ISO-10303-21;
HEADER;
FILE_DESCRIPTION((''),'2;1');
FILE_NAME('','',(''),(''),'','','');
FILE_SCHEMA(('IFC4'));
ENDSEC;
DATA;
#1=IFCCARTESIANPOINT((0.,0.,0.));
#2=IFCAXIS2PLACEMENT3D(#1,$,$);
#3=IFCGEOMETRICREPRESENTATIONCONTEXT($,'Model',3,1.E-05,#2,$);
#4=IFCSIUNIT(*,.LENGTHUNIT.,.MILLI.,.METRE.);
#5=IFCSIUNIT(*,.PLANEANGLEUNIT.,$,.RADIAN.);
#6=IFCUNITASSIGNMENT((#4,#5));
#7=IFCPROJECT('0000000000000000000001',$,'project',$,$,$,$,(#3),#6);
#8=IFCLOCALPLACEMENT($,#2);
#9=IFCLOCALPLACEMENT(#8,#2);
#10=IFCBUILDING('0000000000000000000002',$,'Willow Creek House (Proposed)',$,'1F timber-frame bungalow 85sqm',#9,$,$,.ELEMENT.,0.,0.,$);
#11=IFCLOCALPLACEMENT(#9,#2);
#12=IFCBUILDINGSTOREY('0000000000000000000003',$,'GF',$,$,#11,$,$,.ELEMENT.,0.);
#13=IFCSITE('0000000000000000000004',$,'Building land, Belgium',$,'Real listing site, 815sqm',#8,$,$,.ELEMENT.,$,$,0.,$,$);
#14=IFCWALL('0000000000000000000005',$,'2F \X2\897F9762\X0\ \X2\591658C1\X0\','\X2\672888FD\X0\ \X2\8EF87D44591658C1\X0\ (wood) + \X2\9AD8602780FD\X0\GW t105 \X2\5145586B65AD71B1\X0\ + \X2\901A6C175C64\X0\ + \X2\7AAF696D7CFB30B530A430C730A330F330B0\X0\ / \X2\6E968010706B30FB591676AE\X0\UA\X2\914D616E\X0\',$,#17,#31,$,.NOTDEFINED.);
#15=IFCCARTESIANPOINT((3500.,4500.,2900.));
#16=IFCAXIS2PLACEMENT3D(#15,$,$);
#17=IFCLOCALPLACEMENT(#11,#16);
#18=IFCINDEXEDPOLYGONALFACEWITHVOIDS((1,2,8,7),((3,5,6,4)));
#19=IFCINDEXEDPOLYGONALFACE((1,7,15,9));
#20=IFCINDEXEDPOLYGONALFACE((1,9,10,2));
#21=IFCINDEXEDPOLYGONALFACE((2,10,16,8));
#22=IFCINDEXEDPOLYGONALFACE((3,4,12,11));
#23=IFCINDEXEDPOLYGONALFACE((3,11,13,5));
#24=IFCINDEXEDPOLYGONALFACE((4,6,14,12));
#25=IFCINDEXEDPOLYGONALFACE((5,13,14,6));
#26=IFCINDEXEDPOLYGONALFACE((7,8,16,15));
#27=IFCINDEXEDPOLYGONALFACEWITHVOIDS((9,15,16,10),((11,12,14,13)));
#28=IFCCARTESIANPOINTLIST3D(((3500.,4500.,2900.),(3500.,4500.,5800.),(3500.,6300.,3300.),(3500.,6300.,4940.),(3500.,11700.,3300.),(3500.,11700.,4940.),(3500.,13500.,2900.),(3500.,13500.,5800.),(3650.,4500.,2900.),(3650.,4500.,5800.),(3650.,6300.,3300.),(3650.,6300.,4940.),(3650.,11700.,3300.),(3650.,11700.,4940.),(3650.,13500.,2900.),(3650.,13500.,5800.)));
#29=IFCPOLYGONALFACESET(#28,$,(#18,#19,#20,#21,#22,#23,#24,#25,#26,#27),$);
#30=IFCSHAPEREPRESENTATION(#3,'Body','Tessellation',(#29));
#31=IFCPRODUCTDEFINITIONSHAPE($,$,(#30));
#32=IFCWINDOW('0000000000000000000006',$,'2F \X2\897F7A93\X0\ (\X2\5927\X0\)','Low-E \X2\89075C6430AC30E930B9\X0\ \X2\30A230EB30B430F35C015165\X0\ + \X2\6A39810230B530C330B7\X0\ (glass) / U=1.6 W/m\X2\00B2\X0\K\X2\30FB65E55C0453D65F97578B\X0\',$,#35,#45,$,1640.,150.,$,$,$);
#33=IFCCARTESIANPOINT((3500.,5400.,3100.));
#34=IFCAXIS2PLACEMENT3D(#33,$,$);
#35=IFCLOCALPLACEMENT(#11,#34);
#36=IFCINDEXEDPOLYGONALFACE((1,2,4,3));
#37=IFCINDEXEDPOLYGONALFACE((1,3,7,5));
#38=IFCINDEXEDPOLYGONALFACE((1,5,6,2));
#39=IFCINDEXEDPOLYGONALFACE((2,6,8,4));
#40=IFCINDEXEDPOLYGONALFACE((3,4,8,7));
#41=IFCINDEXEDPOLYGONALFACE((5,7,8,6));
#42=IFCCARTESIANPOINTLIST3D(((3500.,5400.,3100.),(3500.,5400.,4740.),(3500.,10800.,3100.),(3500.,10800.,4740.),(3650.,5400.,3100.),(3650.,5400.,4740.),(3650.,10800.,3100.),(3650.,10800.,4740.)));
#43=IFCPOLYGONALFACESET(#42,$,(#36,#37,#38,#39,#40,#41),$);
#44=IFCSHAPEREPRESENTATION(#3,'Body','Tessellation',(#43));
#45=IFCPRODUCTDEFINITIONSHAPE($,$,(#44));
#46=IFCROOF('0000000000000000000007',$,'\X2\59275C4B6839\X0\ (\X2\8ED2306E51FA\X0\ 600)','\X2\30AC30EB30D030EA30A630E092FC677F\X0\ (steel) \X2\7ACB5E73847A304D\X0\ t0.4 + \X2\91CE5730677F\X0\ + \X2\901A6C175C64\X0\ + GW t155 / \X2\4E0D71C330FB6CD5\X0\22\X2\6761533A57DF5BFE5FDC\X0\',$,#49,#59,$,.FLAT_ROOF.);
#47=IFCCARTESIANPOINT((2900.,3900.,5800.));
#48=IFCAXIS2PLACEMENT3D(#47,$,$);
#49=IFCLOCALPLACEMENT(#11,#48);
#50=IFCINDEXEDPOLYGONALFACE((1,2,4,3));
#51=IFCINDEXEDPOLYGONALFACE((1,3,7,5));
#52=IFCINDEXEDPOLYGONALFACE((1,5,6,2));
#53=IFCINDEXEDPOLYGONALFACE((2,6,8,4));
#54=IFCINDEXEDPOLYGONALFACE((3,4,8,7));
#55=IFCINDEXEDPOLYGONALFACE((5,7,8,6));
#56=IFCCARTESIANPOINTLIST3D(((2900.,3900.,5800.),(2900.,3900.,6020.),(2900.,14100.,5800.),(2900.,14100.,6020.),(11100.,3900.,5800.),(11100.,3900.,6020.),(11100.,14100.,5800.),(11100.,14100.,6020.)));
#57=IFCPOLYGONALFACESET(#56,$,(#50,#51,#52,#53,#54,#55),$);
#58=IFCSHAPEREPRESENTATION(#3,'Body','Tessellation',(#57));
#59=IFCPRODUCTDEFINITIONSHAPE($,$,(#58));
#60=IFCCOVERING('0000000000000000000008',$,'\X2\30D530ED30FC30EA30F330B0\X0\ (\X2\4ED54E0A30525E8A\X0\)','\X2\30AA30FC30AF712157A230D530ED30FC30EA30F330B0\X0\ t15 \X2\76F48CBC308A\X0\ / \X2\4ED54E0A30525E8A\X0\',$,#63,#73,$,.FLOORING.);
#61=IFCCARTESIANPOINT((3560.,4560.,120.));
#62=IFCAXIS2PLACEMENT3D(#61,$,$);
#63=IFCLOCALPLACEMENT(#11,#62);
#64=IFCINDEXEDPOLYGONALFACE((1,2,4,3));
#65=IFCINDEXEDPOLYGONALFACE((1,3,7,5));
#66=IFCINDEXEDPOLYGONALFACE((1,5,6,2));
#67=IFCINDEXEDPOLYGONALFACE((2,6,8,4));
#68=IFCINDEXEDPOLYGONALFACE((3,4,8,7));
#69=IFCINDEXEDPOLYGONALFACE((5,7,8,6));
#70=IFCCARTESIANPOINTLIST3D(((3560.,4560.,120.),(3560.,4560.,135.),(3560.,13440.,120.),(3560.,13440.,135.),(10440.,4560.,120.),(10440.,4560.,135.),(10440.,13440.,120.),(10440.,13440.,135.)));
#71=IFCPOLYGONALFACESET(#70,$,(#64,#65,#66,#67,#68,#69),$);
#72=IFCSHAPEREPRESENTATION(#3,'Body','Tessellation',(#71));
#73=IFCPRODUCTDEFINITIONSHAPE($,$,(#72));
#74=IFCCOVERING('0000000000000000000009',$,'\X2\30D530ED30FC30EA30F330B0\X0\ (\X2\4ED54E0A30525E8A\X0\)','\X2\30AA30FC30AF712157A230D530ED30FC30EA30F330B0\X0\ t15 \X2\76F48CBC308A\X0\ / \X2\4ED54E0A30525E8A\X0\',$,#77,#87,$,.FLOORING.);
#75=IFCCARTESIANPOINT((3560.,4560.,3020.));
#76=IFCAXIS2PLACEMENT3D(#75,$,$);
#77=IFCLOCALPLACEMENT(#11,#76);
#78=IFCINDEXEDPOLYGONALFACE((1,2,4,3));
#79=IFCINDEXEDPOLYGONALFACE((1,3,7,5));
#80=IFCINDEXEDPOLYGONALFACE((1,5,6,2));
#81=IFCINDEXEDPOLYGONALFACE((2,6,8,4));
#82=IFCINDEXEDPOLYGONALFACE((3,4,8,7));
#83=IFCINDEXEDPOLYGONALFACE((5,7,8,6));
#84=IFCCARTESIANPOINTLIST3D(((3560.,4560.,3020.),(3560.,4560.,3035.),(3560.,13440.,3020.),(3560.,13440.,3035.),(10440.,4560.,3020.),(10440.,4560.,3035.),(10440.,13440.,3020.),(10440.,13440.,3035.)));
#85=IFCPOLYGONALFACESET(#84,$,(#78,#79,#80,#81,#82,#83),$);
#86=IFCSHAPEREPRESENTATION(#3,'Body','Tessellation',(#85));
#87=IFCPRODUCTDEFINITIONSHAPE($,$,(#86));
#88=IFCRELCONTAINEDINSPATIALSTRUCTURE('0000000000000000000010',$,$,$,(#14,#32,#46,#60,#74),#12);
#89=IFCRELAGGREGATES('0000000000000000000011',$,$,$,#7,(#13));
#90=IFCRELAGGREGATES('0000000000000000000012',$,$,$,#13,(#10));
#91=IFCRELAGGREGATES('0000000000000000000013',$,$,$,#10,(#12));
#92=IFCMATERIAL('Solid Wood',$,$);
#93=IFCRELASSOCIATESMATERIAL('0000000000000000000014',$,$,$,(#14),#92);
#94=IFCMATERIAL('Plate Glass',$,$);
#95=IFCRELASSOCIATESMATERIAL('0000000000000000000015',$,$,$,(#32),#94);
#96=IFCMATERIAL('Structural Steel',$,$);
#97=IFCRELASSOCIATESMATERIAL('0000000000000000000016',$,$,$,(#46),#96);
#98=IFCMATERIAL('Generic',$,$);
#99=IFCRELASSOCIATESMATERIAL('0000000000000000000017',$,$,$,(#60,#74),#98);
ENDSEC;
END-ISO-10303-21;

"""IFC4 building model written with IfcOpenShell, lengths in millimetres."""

from ifc_helpers import new_model, si_unit, frame, frame_2d, origin, place, context, project, spatial, rectangle, extrude, material, element, fill, save


model = new_model("IFC4")

# Units and contexts
model_context = context("Model", 3, precision=1e-05, world=origin())
ifc_project = project(units=[si_unit("LENGTHUNIT", "METRE", prefix="MILLI"), si_unit("PLANEANGLEUNIT", "RADIAN")], contexts=[model_context])

# Site, building, storey
site_placement = place(None, origin())
site = spatial("IfcSite", under=ifc_project, at=site_placement, Name="Building land, Belgium", ObjectType="Real listing site, 815sqm", CompositionType="ELEMENT", RefElevation=0.0)
building_placement = place(site_placement, origin())
building = spatial("IfcBuilding", under=site, at=building_placement, Name="Willow Creek House (Proposed)", ObjectType="1F timber-frame bungalow 85sqm", CompositionType="ELEMENT", ElevationOfRefHeight=0.0, ElevationOfTerrain=0.0)
storey_placement = place(building_placement, origin())
storey = spatial("IfcBuildingStorey", under=building, at=storey_placement, Name="GF", CompositionType="ELEMENT", Elevation=0.0)

# Shared definitions
ifc_material_1 = material(Name="Solid Wood")
ifc_material_2 = material(Name="Generic")

# Shared definitions
ifc_material_3 = material(Name="Plate Glass")

# Wall, opening, window
wall_1_placement = place(storey_placement, frame((3500.0, 4500.0, 2900.0)))
wall_1 = element("IfcWall", 1, at=wall_1_placement, inside=storey, material=ifc_material_1, Name="2F 西面 外壁", Description="木製 軸組外壁 (wood) + 高性能GW t105 充填断熱 + 通気層 + 窯業系サイディング / 準耐火・外皮UA配慮", PredefinedType="NOTDEFINED", context=model_context, shape_type="SweptSolid", body=[
    extrude(rectangle(XDim=150.0, YDim=9000.0, at=frame_2d((75.0, 4500.0))), frame((3500.0, 4500.0, 2900.0)), (0.0, 0.0, 1.0), 2900.0),
])
opening_1_placement = place(storey_placement, frame((3500.0, 5400.0, 3100.0)))
opening_1 = element("IfcOpeningElement", 2, at=opening_1_placement, cuts=wall_1, PredefinedType="NOTDEFINED", context=model_context, shape_type="SweptSolid", body=[
    extrude(rectangle(XDim=150.0, YDim=5400.0, at=frame_2d((75.0, 2700.0))), frame((3500.0, 5400.0, 3100.0)), (0.0, 0.0, 1.0), 1640.0),
])
window_1_placement = place(storey_placement, frame((3500.0, 5400.0, 3100.0)))
window_1 = element("IfcWindow", 3, at=window_1_placement, inside=storey, material=ifc_material_3, Name="2F 西窓 (大)", Description="Low-E 複層ガラス アルゴン封入 + 樹脂サッシ (glass) / U=1.6 W/m²K・日射取得型", OverallHeight=1640.0, OverallWidth=150.0, context=model_context, shape_type="SweptSolid", body=[
    extrude(rectangle(XDim=150.0, YDim=5400.0, at=frame_2d((75.0, 2700.0))), frame((3500.0, 5400.0, 3100.0)), (0.0, 0.0, 1.0), 1640.0),
])
fill(opening_1, window_1)

# Roof
ifc_material_4 = material(Name="Structural Steel")
roof_placement = place(storey_placement, frame((2900.0, 3900.0, 5800.0)))
element("IfcRoof", 4, at=roof_placement, inside=storey, material=ifc_material_4, Name="大屋根 (軒の出 600)", Description="ガルバリウム鋼板 (steel) 立平葺き t0.4 + 野地板 + 通気層 + GW t155 / 不燃・法22条区域対応", PredefinedType="FLAT_ROOF", context=model_context, shape_type="SweptSolid", body=[
    extrude(rectangle(XDim=8200.0, YDim=10200.0, at=frame_2d((4100.0, 5100.0))), frame((2900.0, 3900.0, 5800.0)), (0.0, 0.0, 1.0), 220.0),
])

# Coverings
covering_1_placement = place(storey_placement, frame((3560.0, 4560.0, 120.0)))
element("IfcCovering", 5, at=covering_1_placement, inside=storey, material=ifc_material_2, Name="フローリング (仕上げ床)", Description="オーク無垢フローリング t15 直貼り / 仕上げ床", PredefinedType="FLOORING", context=model_context, shape_type="SweptSolid", body=[
    extrude(rectangle(XDim=6880.0, YDim=8880.0, at=frame_2d((3440.0, 4440.0))), frame((3560.0, 4560.0, 120.0)), (0.0, 0.0, 1.0), 15.0),
])
covering_2_placement = place(storey_placement, frame((3560.0, 4560.0, 3020.0)))
element("IfcCovering", 6, at=covering_2_placement, inside=storey, material=ifc_material_2, Name="フローリング (仕上げ床)", Description="オーク無垢フローリング t15 直貼り / 仕上げ床", PredefinedType="FLOORING", context=model_context, shape_type="SweptSolid", body=[
    extrude(rectangle(XDim=6880.0, YDim=8880.0, at=frame_2d((3440.0, 4440.0))), frame((3560.0, 4560.0, 3020.0)), (0.0, 0.0, 1.0), 15.0),
])

save(model, "model.ifc")
